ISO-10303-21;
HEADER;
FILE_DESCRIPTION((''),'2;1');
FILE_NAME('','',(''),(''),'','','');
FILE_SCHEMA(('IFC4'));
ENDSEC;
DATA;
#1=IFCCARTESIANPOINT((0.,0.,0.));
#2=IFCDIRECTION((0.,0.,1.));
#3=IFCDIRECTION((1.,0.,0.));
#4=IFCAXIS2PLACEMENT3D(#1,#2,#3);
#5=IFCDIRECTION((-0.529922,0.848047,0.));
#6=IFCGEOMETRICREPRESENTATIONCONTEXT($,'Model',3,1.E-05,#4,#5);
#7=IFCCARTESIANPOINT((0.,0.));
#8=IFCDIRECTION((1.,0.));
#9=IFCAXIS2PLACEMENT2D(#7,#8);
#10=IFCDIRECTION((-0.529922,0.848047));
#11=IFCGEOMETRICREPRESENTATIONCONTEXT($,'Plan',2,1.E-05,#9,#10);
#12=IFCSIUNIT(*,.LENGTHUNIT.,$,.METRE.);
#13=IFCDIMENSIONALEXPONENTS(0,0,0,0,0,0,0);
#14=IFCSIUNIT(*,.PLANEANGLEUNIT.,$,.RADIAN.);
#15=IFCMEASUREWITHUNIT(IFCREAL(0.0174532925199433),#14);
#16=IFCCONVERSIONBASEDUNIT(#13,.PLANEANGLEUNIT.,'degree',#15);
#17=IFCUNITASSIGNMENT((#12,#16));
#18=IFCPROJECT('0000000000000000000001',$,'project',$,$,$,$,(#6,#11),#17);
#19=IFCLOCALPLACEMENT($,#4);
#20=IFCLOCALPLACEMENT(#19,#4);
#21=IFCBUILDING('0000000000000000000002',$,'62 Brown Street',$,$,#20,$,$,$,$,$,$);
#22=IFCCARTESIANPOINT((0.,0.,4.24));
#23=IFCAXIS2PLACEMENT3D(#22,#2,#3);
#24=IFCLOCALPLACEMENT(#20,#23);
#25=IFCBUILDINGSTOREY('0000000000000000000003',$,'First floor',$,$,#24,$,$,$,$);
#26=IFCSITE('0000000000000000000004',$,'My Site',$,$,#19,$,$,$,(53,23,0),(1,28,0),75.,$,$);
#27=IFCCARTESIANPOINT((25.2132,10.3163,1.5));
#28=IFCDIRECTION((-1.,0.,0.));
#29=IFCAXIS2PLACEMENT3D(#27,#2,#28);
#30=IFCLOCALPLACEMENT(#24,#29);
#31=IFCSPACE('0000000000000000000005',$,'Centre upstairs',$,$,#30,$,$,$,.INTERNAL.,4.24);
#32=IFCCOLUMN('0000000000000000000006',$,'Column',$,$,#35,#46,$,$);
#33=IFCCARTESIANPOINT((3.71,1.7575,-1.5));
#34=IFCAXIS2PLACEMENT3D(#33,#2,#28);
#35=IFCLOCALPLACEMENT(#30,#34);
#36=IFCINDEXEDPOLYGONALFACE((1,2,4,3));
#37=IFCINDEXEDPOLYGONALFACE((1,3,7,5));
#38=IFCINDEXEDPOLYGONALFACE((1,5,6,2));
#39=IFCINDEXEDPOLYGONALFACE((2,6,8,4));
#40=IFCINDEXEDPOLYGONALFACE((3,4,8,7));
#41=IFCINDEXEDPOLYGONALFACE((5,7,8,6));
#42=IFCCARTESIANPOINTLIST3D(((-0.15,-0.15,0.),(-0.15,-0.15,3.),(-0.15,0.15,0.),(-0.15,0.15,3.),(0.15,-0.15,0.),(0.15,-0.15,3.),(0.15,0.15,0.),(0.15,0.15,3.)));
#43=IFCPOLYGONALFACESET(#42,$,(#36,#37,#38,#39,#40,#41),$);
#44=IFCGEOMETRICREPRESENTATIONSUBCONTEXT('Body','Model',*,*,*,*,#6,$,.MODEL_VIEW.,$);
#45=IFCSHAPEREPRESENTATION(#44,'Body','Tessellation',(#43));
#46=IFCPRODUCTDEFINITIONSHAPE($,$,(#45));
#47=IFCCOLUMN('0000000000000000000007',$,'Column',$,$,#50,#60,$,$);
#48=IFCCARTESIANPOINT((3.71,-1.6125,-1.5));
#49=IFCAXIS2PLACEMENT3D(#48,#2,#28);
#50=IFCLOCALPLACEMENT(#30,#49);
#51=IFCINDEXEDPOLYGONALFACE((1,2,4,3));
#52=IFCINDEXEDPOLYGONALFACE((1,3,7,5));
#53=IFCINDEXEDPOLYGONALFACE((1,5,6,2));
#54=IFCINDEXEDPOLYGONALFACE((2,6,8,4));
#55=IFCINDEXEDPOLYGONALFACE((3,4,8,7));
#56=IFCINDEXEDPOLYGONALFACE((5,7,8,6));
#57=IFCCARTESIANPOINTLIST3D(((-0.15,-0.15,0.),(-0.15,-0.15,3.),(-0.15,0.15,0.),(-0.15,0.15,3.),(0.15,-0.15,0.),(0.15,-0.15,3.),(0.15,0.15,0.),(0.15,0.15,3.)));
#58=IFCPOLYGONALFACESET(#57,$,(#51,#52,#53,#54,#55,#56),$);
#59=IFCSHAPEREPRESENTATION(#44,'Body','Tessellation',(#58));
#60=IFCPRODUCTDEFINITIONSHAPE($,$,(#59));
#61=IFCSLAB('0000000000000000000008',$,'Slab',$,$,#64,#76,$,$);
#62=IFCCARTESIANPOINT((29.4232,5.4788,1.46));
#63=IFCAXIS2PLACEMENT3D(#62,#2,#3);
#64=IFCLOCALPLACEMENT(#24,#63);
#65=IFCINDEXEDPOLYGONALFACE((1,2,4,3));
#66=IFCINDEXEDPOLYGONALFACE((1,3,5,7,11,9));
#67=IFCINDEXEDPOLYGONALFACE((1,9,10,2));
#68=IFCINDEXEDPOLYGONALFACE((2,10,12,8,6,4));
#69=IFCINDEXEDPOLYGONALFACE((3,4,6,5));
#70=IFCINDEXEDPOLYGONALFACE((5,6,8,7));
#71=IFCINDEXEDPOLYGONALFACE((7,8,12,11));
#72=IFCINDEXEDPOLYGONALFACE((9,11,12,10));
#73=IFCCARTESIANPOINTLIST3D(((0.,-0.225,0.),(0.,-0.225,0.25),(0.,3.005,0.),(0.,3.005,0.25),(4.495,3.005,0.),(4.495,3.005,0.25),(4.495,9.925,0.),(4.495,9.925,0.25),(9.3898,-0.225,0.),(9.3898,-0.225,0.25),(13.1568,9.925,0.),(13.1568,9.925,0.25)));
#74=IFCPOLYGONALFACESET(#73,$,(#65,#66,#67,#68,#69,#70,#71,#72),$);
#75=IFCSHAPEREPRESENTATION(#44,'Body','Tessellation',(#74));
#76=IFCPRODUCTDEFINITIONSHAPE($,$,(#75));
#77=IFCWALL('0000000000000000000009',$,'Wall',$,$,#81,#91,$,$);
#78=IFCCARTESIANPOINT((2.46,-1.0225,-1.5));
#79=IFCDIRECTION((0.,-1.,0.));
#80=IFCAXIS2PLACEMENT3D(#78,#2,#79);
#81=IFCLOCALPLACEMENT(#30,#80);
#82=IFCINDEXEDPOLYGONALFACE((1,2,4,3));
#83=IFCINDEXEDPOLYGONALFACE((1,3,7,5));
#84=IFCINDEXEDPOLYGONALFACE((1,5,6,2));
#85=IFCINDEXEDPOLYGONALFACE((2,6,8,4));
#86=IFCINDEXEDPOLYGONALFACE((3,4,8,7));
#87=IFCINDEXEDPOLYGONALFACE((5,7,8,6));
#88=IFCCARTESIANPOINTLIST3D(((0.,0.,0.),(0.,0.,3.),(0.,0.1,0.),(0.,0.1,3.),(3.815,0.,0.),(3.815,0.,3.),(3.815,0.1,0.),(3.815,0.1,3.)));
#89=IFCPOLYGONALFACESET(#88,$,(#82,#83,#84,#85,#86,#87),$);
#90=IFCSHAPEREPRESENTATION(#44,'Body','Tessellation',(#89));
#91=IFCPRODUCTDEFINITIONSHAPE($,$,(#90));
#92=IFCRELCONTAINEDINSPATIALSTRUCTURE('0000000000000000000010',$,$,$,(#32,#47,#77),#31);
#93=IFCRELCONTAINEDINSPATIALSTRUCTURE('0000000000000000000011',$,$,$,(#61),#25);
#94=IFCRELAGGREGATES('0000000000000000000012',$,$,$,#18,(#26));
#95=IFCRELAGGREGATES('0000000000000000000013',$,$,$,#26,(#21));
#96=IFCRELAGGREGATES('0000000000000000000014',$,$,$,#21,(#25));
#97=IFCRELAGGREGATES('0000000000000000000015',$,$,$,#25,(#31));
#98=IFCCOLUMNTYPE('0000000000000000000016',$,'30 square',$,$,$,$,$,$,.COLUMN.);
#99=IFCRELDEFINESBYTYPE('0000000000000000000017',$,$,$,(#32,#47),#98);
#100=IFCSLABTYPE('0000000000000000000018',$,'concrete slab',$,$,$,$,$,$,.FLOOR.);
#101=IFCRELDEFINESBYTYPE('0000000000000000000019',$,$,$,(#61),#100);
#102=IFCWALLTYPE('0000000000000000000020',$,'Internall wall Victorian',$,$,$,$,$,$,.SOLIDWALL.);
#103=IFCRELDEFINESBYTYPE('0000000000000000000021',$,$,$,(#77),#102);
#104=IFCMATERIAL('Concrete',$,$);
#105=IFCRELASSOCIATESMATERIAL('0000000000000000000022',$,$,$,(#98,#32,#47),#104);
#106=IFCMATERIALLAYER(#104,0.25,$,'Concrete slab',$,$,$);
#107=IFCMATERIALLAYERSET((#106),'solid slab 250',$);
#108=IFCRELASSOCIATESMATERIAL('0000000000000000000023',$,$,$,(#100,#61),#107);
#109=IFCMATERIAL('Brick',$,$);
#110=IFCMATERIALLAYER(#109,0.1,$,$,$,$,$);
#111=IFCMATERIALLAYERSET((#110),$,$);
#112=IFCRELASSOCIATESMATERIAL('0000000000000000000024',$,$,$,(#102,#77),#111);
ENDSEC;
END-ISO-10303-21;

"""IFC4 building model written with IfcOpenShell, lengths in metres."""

from ifc_helpers import new_model, entity, si_unit, converted_unit, direction, frame, origin_with_axes, origin_2d_with_axis, place, context, subcontext, project, spatial, line, indexed_curve, rectangle, outline, extrude, material, layer, layer_set, layer_usage, material_profile, profile_set, profile_usage, type_object, element, save


model = new_model("IFC4")

# Units and contexts
model_context = context("Model", 3, precision=1e-05, world=origin_with_axes(), true_north=direction((-0.529922, 0.848047, 0.0)))
plan_context = context("Plan", 2, precision=1e-05, world=origin_2d_with_axis(), true_north=direction((-0.529922, 0.848047)))
body_context = subcontext(model_context, "Body", "Model", "MODEL_VIEW")
ifc_project = project(units=[si_unit("LENGTHUNIT", "METRE"), converted_unit("PLANEANGLEUNIT", "degree", entity("IfcReal", 0.0174532925199433), si_unit("PLANEANGLEUNIT", "RADIAN"), dimensions=[0, 0, 0, 0, 0, 0, 0])], contexts=[model_context, plan_context])

# Site, building, storey, space
site_placement = place(None, origin_with_axes())
site = spatial("IfcSite", under=ifc_project, at=site_placement, Name="My Site", RefLatitude=(53, 23, 0), RefLongitude=(1, 28, 0), RefElevation=75.0)
building_placement = place(site_placement, origin_with_axes())
building = spatial("IfcBuilding", under=site, at=building_placement, Name="62 Brown Street")
storey_placement = place(building_placement, frame((0.0, 0.0, 4.24), z_axis=(0.0, 0.0, 1.0), x_axis=(1.0, 0.0, 0.0)))
storey = spatial("IfcBuildingStorey", under=building, at=storey_placement, Name="First floor")
space_placement = place(storey_placement, frame((25.2132, 10.3163, 1.5), z_axis=(0.0, 0.0, 1.0), x_axis=(-1.0, 0.0, 0.0)))
space = spatial("IfcSpace", under=storey, at=space_placement, Name="Centre upstairs", PredefinedType="INTERNAL", ElevationWithFlooring=4.24)

# Columns
ifc_material_1 = material(Name="Concrete")
ifc_material_profile_1 = material_profile(ifc_material_1, rectangle(XDim=0.3, YDim=0.3))
ifc_profile_set_1 = profile_set([ifc_material_profile_1])
ifc_profile_usage_1 = profile_usage(ifc_profile_set_1, cardinal=5)
column_type = type_object("IfcColumnType", Name="30 square", PredefinedType="COLUMN", material=ifc_profile_set_1)
column_1_placement = place(space_placement, frame((3.71, 1.7575, -1.5), z_axis=(0.0, 0.0, 1.0), x_axis=(-1.0, 0.0, 0.0)))
element("IfcColumn", 1, at=column_1_placement, inside=space, type_object=column_type, material=ifc_profile_usage_1, Name="Column", context=body_context, shape_type="SweptSolid", body=[
    extrude(rectangle(XDim=0.3, YDim=0.3), origin_with_axes(), (0.0, 0.0, 1.0), 3.0),
])
ifc_profile_usage_2 = profile_usage(ifc_profile_set_1, cardinal=5)
column_2_placement = place(space_placement, frame((3.71, -1.6125, -1.5), z_axis=(0.0, 0.0, 1.0), x_axis=(-1.0, 0.0, 0.0)))
element("IfcColumn", 2, at=column_2_placement, inside=space, type_object=column_type, material=ifc_profile_usage_2, Name="Column", context=body_context, shape_type="SweptSolid", body=[
    extrude(rectangle(XDim=0.3, YDim=0.3), origin_with_axes(), (0.0, 0.0, 1.0), 3.0),
])

# Slab
ifc_layer_1 = layer(ifc_material_1, 0.25, Name="Concrete slab")
ifc_layer_set_1 = layer_set([ifc_layer_1], Name="solid slab 250")
slab_type = type_object("IfcSlabType", Name="concrete slab", PredefinedType="FLOOR", material=ifc_layer_set_1)
ifc_layer_usage_1 = layer_usage(ifc_layer_set_1, "AXIS3", "POSITIVE", 0.0)
slab_1_placement = place(storey_placement, frame((29.4232, 5.4788, 1.46), z_axis=(0.0, 0.0, 1.0), x_axis=(1.0, 0.0, 0.0)))
element("IfcSlab", 3, at=slab_1_placement, inside=storey, type_object=slab_type, material=ifc_layer_usage_1, Name="Slab", context=body_context, shape_type="SweptSolid", body=[
    extrude(outline(indexed_curve([(0.0, 3.005), (0.0, -0.225), (9.3898, -0.225), (13.1568, 9.925), (4.495, 9.925), (4.495, 3.005)], segments=[line(4, 3), line(3, 2), line(2, 1), line(1, 6), line(6, 5), line(5, 4)], self_intersect=False)), None, (0.0, 0.0, 1.0), 0.25),
])

# Wall
ifc_material_2 = material(Name="Brick")
ifc_layer_2 = layer(ifc_material_2, 0.1)
ifc_layer_set_2 = layer_set([ifc_layer_2])
ifc_layer_usage_2 = layer_usage(ifc_layer_set_2, "AXIS2", "POSITIVE", 0.0)
wall_type_1 = type_object("IfcWallType", Name="Internall wall Victorian", PredefinedType="SOLIDWALL", material=ifc_layer_set_2)
wall_1_placement = place(space_placement, frame((2.46, -1.0225, -1.5), z_axis=(0.0, 0.0, 1.0), x_axis=(0.0, -1.0, 0.0)))
element("IfcWall", 4, at=wall_1_placement, inside=space, type_object=wall_type_1, material=ifc_layer_usage_2, Name="Wall", context=body_context, shape_type="SweptSolid", body=[
    extrude(outline(indexed_curve([(0.0, 0.0), (0.0, 0.1), (3.815, 0.1), (3.815, 0.0), (0.0, 0.0)], self_intersect=False)), origin_with_axes(), (0.0, 0.0, 1.0), 3.0),
])

save(model, "model.ifc")
